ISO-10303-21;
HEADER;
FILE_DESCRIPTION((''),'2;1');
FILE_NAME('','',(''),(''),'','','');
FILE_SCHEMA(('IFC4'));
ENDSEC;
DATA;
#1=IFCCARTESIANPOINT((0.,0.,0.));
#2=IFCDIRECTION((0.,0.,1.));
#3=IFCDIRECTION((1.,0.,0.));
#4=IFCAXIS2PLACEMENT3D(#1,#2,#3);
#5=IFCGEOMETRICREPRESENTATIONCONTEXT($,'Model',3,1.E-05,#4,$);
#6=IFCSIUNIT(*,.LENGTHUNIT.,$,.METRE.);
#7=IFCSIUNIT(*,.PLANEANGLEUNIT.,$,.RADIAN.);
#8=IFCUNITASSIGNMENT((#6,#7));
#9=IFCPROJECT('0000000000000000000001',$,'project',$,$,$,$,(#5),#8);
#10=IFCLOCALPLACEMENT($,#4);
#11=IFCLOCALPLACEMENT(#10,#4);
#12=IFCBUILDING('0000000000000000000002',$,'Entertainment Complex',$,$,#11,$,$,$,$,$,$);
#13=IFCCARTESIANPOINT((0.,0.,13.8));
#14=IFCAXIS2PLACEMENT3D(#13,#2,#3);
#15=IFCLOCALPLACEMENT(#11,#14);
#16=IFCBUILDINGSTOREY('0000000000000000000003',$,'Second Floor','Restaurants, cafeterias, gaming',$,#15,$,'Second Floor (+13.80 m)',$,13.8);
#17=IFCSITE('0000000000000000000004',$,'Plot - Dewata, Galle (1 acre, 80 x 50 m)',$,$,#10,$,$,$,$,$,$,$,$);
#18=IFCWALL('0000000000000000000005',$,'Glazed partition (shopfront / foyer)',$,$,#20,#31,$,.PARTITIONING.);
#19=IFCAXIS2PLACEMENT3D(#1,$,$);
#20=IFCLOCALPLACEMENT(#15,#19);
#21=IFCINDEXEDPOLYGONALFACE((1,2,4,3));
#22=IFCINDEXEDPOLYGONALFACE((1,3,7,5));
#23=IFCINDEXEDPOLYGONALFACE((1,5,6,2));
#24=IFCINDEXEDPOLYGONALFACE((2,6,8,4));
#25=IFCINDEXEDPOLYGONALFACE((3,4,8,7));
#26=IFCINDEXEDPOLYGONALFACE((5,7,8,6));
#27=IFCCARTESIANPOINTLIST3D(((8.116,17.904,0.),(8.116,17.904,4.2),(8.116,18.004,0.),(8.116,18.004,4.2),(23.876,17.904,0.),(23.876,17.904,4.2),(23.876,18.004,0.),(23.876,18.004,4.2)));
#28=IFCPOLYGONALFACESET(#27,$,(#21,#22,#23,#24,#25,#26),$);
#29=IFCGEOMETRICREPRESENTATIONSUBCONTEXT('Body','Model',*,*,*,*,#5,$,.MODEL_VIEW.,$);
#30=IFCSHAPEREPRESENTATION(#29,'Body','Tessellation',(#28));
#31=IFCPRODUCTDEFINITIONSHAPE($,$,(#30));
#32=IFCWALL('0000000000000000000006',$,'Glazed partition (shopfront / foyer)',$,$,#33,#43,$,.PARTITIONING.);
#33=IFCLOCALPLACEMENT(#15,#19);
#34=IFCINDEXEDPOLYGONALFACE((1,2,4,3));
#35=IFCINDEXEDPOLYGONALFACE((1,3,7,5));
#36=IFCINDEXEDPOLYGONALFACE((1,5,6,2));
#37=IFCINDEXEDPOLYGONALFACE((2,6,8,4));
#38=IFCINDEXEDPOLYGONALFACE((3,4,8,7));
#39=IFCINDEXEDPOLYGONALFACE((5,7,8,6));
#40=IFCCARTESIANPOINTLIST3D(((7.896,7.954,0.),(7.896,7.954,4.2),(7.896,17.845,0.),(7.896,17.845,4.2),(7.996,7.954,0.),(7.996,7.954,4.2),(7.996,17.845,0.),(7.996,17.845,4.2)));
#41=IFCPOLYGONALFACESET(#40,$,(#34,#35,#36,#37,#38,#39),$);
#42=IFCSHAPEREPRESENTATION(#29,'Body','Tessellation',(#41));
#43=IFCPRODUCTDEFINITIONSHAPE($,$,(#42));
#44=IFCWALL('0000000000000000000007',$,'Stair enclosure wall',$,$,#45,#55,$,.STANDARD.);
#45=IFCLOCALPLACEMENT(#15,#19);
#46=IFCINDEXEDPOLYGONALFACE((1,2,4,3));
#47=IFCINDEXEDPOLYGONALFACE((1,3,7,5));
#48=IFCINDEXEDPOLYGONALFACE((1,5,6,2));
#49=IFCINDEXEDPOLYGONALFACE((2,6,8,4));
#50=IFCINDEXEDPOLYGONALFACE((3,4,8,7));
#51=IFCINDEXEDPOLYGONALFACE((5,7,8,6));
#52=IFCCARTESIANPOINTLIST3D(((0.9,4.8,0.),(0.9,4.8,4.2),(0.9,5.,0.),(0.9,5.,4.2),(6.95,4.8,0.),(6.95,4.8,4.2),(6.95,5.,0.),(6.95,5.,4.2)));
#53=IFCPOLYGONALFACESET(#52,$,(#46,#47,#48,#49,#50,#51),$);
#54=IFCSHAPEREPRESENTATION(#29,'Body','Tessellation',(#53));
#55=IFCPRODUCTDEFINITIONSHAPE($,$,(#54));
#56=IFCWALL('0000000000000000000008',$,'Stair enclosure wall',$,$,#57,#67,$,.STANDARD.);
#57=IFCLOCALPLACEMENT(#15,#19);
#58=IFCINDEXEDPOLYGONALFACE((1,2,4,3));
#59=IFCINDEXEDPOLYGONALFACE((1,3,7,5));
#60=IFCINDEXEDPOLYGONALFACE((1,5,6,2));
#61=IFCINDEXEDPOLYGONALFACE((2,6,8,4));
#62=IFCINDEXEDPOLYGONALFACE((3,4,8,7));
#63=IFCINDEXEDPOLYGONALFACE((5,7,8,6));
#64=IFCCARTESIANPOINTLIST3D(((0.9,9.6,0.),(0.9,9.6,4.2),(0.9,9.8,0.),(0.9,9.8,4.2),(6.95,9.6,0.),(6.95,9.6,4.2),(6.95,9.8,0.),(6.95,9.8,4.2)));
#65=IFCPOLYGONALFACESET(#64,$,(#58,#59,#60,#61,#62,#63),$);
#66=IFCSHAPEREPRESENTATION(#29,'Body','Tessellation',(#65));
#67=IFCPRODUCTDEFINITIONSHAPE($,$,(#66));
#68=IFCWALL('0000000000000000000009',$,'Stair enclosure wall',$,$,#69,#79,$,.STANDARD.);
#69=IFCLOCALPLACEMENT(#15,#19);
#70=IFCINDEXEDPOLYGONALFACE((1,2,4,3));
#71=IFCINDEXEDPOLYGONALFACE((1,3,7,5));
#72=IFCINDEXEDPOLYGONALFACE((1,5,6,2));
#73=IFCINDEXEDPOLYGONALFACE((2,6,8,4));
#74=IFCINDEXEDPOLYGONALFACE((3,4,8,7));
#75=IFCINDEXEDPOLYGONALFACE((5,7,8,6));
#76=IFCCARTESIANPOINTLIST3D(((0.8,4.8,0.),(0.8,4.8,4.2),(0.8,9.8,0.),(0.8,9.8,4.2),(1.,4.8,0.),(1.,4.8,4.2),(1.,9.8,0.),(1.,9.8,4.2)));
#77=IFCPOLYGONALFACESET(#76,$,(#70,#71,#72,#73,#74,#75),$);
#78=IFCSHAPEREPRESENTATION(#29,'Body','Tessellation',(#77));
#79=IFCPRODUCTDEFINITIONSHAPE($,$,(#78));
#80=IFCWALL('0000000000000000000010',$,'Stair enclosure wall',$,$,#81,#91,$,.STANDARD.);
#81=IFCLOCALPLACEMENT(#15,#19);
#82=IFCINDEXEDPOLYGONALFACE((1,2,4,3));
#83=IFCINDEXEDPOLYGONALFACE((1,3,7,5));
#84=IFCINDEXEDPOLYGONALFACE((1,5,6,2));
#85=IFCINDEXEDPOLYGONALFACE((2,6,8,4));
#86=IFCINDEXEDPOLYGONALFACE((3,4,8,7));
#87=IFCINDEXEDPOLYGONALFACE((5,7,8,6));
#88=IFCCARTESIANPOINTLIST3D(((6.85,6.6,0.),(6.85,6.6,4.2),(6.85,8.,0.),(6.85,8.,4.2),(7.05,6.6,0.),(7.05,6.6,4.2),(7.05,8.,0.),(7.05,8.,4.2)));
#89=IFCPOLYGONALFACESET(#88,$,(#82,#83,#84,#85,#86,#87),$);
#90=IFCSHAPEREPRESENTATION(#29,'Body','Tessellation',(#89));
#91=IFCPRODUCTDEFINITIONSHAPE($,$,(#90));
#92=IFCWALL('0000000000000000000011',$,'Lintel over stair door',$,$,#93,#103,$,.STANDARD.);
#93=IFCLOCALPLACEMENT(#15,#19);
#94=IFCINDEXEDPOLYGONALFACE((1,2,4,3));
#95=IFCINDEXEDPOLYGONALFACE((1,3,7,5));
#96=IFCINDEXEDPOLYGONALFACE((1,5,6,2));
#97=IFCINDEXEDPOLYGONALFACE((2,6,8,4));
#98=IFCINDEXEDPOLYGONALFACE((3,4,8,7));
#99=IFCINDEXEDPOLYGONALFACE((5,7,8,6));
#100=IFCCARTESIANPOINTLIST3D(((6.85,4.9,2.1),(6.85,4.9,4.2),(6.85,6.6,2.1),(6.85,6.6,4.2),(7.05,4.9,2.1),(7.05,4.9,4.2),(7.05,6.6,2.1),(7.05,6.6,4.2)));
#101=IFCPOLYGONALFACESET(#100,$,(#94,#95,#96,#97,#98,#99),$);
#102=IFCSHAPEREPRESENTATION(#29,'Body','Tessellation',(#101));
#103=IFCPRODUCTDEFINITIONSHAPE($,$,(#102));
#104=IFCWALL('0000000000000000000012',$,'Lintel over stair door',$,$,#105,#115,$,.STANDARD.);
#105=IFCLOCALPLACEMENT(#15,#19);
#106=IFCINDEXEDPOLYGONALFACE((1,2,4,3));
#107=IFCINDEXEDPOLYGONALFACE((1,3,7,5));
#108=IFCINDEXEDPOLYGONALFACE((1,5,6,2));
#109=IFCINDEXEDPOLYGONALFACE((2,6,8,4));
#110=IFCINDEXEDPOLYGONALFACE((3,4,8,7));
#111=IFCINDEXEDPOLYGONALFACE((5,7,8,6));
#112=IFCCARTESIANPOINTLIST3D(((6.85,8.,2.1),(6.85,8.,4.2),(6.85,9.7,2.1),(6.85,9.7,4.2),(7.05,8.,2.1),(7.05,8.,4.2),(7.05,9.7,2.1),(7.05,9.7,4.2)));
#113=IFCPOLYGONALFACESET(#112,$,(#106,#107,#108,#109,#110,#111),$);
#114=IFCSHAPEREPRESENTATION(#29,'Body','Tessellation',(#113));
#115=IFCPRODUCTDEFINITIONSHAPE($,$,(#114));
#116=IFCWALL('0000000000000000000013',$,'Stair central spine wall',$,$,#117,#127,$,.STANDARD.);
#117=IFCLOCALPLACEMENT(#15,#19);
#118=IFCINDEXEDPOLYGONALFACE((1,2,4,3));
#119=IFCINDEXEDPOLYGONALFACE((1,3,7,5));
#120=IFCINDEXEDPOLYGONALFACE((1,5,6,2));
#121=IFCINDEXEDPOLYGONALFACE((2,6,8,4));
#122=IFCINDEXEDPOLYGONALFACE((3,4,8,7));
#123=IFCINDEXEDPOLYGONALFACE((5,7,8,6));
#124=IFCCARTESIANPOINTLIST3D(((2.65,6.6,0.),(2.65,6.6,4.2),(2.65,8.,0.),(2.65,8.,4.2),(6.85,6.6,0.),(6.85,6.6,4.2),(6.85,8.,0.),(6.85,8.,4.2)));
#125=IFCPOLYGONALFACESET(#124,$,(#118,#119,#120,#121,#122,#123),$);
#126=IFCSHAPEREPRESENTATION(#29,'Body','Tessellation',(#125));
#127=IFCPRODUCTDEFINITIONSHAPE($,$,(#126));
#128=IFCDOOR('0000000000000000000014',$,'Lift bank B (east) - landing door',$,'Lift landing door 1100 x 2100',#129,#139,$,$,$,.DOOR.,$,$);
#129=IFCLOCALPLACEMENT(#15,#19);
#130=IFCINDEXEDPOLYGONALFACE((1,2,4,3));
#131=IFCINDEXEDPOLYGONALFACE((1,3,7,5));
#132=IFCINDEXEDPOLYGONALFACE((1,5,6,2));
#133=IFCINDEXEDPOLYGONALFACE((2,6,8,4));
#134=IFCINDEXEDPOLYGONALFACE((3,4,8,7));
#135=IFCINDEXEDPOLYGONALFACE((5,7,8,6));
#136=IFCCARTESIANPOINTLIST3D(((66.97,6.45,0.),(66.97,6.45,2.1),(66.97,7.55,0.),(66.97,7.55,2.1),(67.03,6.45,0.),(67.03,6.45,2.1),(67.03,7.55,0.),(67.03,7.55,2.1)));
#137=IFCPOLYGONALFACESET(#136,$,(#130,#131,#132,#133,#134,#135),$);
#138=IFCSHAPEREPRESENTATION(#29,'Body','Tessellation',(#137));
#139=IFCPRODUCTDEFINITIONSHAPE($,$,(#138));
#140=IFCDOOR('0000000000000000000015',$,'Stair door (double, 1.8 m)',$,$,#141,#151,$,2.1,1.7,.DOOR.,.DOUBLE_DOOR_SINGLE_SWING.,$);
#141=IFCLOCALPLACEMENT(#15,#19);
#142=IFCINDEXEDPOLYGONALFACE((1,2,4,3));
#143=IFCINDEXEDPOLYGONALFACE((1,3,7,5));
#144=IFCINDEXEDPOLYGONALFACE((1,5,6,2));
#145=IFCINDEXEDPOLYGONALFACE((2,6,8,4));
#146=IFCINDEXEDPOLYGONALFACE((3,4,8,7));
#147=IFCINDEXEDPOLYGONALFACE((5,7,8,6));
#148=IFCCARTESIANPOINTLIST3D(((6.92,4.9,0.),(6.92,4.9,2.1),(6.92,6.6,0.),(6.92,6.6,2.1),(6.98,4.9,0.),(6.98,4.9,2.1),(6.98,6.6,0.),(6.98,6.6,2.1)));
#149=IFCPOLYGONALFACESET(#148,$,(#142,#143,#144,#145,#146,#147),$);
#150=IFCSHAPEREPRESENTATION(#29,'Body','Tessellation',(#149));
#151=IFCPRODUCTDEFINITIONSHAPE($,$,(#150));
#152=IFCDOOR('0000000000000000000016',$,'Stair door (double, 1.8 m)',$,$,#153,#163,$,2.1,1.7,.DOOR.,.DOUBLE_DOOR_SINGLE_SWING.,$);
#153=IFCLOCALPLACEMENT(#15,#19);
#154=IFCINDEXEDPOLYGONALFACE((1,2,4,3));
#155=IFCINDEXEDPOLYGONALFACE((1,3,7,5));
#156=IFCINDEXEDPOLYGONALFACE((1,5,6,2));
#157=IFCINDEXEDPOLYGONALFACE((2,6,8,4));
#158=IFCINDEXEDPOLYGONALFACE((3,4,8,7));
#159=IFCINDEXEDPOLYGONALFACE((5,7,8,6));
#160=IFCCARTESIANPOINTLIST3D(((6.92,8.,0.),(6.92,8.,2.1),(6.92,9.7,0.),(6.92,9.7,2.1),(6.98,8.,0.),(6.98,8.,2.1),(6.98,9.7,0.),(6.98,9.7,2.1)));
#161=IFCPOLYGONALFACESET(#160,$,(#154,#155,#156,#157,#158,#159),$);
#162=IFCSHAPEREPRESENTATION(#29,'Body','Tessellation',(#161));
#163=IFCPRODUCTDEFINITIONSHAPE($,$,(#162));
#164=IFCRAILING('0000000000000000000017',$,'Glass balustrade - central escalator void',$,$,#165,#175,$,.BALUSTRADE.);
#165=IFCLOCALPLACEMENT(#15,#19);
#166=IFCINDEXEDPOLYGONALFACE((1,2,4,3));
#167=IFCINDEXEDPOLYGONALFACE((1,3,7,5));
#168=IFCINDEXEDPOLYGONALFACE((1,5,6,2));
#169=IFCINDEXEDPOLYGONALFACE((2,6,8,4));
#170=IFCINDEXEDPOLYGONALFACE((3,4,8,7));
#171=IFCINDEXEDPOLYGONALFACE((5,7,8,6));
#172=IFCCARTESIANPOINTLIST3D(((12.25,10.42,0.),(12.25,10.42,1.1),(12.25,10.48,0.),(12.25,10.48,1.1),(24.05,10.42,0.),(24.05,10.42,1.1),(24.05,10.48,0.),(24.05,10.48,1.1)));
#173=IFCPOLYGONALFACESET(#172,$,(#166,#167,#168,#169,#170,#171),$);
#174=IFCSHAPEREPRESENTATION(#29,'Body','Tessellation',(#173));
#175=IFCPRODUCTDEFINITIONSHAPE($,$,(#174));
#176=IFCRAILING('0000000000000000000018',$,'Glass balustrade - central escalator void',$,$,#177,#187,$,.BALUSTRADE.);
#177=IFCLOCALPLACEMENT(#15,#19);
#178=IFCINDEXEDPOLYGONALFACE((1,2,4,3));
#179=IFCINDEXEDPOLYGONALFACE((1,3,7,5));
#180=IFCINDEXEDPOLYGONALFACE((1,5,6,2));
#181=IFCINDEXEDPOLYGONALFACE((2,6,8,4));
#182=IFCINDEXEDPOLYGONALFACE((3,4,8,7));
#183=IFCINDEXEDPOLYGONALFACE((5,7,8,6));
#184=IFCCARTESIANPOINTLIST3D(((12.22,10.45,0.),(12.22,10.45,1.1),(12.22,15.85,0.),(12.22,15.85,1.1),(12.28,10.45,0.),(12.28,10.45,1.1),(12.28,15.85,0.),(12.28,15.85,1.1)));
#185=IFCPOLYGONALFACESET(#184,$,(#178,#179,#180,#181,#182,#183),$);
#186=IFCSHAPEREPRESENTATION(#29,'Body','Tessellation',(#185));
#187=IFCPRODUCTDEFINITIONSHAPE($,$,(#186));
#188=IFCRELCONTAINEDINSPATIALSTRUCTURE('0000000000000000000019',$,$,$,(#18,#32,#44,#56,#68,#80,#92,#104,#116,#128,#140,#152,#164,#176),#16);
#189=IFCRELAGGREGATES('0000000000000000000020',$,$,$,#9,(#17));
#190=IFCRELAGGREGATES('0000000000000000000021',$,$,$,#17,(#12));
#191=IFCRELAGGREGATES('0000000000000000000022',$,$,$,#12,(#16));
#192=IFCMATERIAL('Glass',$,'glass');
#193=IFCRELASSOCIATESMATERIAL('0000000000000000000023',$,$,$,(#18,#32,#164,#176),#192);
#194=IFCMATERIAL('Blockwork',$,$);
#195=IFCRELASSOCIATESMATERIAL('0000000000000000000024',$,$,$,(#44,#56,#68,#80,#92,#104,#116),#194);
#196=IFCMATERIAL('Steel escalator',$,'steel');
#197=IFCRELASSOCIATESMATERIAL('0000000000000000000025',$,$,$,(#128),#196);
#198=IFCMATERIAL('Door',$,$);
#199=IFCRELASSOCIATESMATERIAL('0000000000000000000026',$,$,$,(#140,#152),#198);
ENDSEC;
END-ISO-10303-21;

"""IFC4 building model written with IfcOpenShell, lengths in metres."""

from ifc_helpers import new_model, si_unit, frame, origin_with_axes, place, context, subcontext, project, spatial, polyline, outline, extrude, material, element, save


model = new_model("IFC4")

# Units and contexts
model_context = context("Model", 3, precision=1e-05, world=origin_with_axes())
body_context = subcontext(model_context, "Body", "Model", "MODEL_VIEW")
ifc_project = project(units=[si_unit("LENGTHUNIT", "METRE"), si_unit("PLANEANGLEUNIT", "RADIAN")], contexts=[model_context])

# Site, building, storey
site_placement = place(None, origin_with_axes())
site = spatial("IfcSite", under=ifc_project, at=site_placement, Name="Plot - Dewata, Galle (1 acre, 80 x 50 m)")
building_placement = place(site_placement, origin_with_axes())
building = spatial("IfcBuilding", under=site, at=building_placement, Name="Entertainment Complex")
storey_placement = place(building_placement, frame((0.0, 0.0, 13.8), z_axis=(0.0, 0.0, 1.0), x_axis=(1.0, 0.0, 0.0)))
storey = spatial("IfcBuildingStorey", under=building, at=storey_placement, Name="Second Floor", Description="Restaurants, cafeterias, gaming", LongName="Second Floor (+13.80 m)", Elevation=13.8)

# Walls
ifc_material_1 = material(Name="Blockwork")
ifc_material_2 = material(Name="Glass", Category="glass")
wall_1_placement = place(storey_placement, frame((8.116, 17.954, 0.0), z_axis=(0.0, 0.0, 1.0), x_axis=(1.0, 0.0, 0.0)))
element("IfcWall", 1, at=wall_1_placement, inside=storey, material=ifc_material_2, Name="Glazed partition (shopfront / foyer)", PredefinedType="PARTITIONING", context=body_context, shape_type="SweptSolid", body=[
    extrude(outline(polyline([(0.0, -0.05), (15.76, -0.05), (15.76, 0.05), (0.0, 0.05), (0.0, -0.05)])), origin_with_axes(), (0.0, 0.0, 1.0), 4.2),
])
wall_2_placement = place(storey_placement, frame((7.946, 7.954, 0.0), z_axis=(0.0, 0.0, 1.0), x_axis=(0.0, 1.0, 0.0)))
element("IfcWall", 2, at=wall_2_placement, inside=storey, material=ifc_material_2, Name="Glazed partition (shopfront / foyer)", PredefinedType="PARTITIONING", context=body_context, shape_type="SweptSolid", body=[
    extrude(outline(polyline([(0.0, -0.05), (9.891, -0.05), (9.891, 0.05), (0.0, 0.05), (0.0, -0.05)])), origin_with_axes(), (0.0, 0.0, 1.0), 4.2),
])
for number, where, z_axis, x_axis, name in (
    (3, (0.9, 4.9, 0.0), (0.0, 0.0, 1.0), (1.0, 0.0, 0.0), "Stair enclosure wall"),
    (4, (0.9, 9.7, 0.0), (0.0, 0.0, 1.0), (1.0, 0.0, 0.0), "Stair enclosure wall"),
):
    element("IfcWall", number, at=place(storey_placement, frame(where, z_axis=z_axis, x_axis=x_axis)), inside=storey, material=ifc_material_1, Name=name, PredefinedType="STANDARD", context=body_context, shape_type="SweptSolid", body=[
        extrude(outline(polyline([(0.0, -0.1), (6.05, -0.1), (6.05, 0.1), (0.0, 0.1), (0.0, -0.1)])), origin_with_axes(), (0.0, 0.0, 1.0), 4.2),
    ])
wall_3_placement = place(storey_placement, frame((0.9, 4.8, 0.0), z_axis=(0.0, 0.0, 1.0), x_axis=(0.0, 1.0, 0.0)))
element("IfcWall", 5, at=wall_3_placement, inside=storey, material=ifc_material_1, Name="Stair enclosure wall", PredefinedType="STANDARD", context=body_context, shape_type="SweptSolid", body=[
    extrude(outline(polyline([(0.0, -0.1), (5.0, -0.1), (5.0, 0.1), (0.0, 0.1), (0.0, -0.1)])), origin_with_axes(), (0.0, 0.0, 1.0), 4.2),
])
wall_4_placement = place(storey_placement, frame((6.95, 6.6, 0.0), z_axis=(0.0, 0.0, 1.0), x_axis=(0.0, 1.0, 0.0)))
element("IfcWall", 6, at=wall_4_placement, inside=storey, material=ifc_material_1, Name="Stair enclosure wall", PredefinedType="STANDARD", context=body_context, shape_type="SweptSolid", body=[
    extrude(outline(polyline([(0.0, -0.1), (1.4, -0.1), (1.4, 0.1), (0.0, 0.1), (0.0, -0.1)])), origin_with_axes(), (0.0, 0.0, 1.0), 4.2),
])
for number, where, z_axis, x_axis, name in (
    (7, (6.95, 4.9, 2.1), (0.0, 0.0, 1.0), (0.0, 1.0, 0.0), "Lintel over stair door"),
    (8, (6.95, 8.0, 2.1), (0.0, 0.0, 1.0), (0.0, 1.0, 0.0), "Lintel over stair door"),
):
    element("IfcWall", number, at=place(storey_placement, frame(where, z_axis=z_axis, x_axis=x_axis)), inside=storey, material=ifc_material_1, Name=name, PredefinedType="STANDARD", context=body_context, shape_type="SweptSolid", body=[
        extrude(outline(polyline([(0.0, -0.1), (1.7, -0.1), (1.7, 0.1), (0.0, 0.1), (0.0, -0.1)])), origin_with_axes(), (0.0, 0.0, 1.0), 2.1),
    ])
wall_5_placement = place(storey_placement, frame((2.65, 7.3, 0.0), z_axis=(0.0, 0.0, 1.0), x_axis=(1.0, 0.0, 0.0)))
element("IfcWall", 9, at=wall_5_placement, inside=storey, material=ifc_material_1, Name="Stair central spine wall", PredefinedType="STANDARD", context=body_context, shape_type="SweptSolid", body=[
    extrude(outline(polyline([(0.0, -0.7), (4.2, -0.7), (4.2, 0.7), (0.0, 0.7), (0.0, -0.7)])), origin_with_axes(), (0.0, 0.0, 1.0), 4.2),
])

# Doors
ifc_material_3 = material(Name="Steel escalator", Category="steel")
door_1_placement = place(storey_placement, origin_with_axes())
element("IfcDoor", 10, at=door_1_placement, inside=storey, material=ifc_material_3, Name="Lift bank B (east) - landing door", ObjectType="Lift landing door 1100 x 2100", PredefinedType="DOOR", context=body_context, shape_type="SweptSolid", body=[
    extrude(outline(polyline([(66.97, 6.45), (67.03, 6.45), (67.03, 7.55), (66.97, 7.55), (66.97, 6.45)])), origin_with_axes(), (0.0, 0.0, 1.0), 2.1),
])
ifc_material_4 = material(Name="Door")
door_2_placement = place(storey_placement, origin_with_axes())
element("IfcDoor", 11, at=door_2_placement, inside=storey, material=ifc_material_4, Name="Stair door (double, 1.8 m)", OperationType="DOUBLE_DOOR_SINGLE_SWING", OverallHeight=2.1, OverallWidth=1.7, PredefinedType="DOOR", context=body_context, shape_type="SweptSolid", body=[
    extrude(outline(polyline([(6.92, 4.9), (6.98, 4.9), (6.98, 6.6), (6.92, 6.6), (6.92, 4.9)])), origin_with_axes(), (0.0, 0.0, 1.0), 2.1),
])
door_3_placement = place(storey_placement, origin_with_axes())
element("IfcDoor", 12, at=door_3_placement, inside=storey, material=ifc_material_4, Name="Stair door (double, 1.8 m)", OperationType="DOUBLE_DOOR_SINGLE_SWING", OverallHeight=2.1, OverallWidth=1.7, PredefinedType="DOOR", context=body_context, shape_type="SweptSolid", body=[
    extrude(outline(polyline([(6.92, 8.0), (6.98, 8.0), (6.98, 9.7), (6.92, 9.7), (6.92, 8.0)])), origin_with_axes(), (0.0, 0.0, 1.0), 2.1),
])

# Railings
railing_1_placement = place(storey_placement, frame((12.25, 10.45, 0.0), z_axis=(0.0, 0.0, 1.0), x_axis=(1.0, 0.0, 0.0)))
element("IfcRailing", 13, at=railing_1_placement, inside=storey, material=ifc_material_2, Name="Glass balustrade - central escalator void", PredefinedType="BALUSTRADE", context=body_context, shape_type="SweptSolid", body=[
    extrude(outline(polyline([(0.0, -0.03), (11.8, -0.03), (11.8, 0.03), (0.0, 0.03), (0.0, -0.03)])), origin_with_axes(), (0.0, 0.0, 1.0), 1.1),
])
railing_2_placement = place(storey_placement, frame((12.25, 15.85, 0.0), z_axis=(0.0, 0.0, 1.0), x_axis=(0.0, -1.0, 0.0)))
element("IfcRailing", 14, at=railing_2_placement, inside=storey, material=ifc_material_2, Name="Glass balustrade - central escalator void", PredefinedType="BALUSTRADE", context=body_context, shape_type="SweptSolid", body=[
    extrude(outline(polyline([(0.0, -0.03), (5.4, -0.03), (5.4, 0.03), (0.0, 0.03), (0.0, -0.03)])), origin_with_axes(), (0.0, 0.0, 1.0), 1.1),
])

save(model, "model.ifc")
